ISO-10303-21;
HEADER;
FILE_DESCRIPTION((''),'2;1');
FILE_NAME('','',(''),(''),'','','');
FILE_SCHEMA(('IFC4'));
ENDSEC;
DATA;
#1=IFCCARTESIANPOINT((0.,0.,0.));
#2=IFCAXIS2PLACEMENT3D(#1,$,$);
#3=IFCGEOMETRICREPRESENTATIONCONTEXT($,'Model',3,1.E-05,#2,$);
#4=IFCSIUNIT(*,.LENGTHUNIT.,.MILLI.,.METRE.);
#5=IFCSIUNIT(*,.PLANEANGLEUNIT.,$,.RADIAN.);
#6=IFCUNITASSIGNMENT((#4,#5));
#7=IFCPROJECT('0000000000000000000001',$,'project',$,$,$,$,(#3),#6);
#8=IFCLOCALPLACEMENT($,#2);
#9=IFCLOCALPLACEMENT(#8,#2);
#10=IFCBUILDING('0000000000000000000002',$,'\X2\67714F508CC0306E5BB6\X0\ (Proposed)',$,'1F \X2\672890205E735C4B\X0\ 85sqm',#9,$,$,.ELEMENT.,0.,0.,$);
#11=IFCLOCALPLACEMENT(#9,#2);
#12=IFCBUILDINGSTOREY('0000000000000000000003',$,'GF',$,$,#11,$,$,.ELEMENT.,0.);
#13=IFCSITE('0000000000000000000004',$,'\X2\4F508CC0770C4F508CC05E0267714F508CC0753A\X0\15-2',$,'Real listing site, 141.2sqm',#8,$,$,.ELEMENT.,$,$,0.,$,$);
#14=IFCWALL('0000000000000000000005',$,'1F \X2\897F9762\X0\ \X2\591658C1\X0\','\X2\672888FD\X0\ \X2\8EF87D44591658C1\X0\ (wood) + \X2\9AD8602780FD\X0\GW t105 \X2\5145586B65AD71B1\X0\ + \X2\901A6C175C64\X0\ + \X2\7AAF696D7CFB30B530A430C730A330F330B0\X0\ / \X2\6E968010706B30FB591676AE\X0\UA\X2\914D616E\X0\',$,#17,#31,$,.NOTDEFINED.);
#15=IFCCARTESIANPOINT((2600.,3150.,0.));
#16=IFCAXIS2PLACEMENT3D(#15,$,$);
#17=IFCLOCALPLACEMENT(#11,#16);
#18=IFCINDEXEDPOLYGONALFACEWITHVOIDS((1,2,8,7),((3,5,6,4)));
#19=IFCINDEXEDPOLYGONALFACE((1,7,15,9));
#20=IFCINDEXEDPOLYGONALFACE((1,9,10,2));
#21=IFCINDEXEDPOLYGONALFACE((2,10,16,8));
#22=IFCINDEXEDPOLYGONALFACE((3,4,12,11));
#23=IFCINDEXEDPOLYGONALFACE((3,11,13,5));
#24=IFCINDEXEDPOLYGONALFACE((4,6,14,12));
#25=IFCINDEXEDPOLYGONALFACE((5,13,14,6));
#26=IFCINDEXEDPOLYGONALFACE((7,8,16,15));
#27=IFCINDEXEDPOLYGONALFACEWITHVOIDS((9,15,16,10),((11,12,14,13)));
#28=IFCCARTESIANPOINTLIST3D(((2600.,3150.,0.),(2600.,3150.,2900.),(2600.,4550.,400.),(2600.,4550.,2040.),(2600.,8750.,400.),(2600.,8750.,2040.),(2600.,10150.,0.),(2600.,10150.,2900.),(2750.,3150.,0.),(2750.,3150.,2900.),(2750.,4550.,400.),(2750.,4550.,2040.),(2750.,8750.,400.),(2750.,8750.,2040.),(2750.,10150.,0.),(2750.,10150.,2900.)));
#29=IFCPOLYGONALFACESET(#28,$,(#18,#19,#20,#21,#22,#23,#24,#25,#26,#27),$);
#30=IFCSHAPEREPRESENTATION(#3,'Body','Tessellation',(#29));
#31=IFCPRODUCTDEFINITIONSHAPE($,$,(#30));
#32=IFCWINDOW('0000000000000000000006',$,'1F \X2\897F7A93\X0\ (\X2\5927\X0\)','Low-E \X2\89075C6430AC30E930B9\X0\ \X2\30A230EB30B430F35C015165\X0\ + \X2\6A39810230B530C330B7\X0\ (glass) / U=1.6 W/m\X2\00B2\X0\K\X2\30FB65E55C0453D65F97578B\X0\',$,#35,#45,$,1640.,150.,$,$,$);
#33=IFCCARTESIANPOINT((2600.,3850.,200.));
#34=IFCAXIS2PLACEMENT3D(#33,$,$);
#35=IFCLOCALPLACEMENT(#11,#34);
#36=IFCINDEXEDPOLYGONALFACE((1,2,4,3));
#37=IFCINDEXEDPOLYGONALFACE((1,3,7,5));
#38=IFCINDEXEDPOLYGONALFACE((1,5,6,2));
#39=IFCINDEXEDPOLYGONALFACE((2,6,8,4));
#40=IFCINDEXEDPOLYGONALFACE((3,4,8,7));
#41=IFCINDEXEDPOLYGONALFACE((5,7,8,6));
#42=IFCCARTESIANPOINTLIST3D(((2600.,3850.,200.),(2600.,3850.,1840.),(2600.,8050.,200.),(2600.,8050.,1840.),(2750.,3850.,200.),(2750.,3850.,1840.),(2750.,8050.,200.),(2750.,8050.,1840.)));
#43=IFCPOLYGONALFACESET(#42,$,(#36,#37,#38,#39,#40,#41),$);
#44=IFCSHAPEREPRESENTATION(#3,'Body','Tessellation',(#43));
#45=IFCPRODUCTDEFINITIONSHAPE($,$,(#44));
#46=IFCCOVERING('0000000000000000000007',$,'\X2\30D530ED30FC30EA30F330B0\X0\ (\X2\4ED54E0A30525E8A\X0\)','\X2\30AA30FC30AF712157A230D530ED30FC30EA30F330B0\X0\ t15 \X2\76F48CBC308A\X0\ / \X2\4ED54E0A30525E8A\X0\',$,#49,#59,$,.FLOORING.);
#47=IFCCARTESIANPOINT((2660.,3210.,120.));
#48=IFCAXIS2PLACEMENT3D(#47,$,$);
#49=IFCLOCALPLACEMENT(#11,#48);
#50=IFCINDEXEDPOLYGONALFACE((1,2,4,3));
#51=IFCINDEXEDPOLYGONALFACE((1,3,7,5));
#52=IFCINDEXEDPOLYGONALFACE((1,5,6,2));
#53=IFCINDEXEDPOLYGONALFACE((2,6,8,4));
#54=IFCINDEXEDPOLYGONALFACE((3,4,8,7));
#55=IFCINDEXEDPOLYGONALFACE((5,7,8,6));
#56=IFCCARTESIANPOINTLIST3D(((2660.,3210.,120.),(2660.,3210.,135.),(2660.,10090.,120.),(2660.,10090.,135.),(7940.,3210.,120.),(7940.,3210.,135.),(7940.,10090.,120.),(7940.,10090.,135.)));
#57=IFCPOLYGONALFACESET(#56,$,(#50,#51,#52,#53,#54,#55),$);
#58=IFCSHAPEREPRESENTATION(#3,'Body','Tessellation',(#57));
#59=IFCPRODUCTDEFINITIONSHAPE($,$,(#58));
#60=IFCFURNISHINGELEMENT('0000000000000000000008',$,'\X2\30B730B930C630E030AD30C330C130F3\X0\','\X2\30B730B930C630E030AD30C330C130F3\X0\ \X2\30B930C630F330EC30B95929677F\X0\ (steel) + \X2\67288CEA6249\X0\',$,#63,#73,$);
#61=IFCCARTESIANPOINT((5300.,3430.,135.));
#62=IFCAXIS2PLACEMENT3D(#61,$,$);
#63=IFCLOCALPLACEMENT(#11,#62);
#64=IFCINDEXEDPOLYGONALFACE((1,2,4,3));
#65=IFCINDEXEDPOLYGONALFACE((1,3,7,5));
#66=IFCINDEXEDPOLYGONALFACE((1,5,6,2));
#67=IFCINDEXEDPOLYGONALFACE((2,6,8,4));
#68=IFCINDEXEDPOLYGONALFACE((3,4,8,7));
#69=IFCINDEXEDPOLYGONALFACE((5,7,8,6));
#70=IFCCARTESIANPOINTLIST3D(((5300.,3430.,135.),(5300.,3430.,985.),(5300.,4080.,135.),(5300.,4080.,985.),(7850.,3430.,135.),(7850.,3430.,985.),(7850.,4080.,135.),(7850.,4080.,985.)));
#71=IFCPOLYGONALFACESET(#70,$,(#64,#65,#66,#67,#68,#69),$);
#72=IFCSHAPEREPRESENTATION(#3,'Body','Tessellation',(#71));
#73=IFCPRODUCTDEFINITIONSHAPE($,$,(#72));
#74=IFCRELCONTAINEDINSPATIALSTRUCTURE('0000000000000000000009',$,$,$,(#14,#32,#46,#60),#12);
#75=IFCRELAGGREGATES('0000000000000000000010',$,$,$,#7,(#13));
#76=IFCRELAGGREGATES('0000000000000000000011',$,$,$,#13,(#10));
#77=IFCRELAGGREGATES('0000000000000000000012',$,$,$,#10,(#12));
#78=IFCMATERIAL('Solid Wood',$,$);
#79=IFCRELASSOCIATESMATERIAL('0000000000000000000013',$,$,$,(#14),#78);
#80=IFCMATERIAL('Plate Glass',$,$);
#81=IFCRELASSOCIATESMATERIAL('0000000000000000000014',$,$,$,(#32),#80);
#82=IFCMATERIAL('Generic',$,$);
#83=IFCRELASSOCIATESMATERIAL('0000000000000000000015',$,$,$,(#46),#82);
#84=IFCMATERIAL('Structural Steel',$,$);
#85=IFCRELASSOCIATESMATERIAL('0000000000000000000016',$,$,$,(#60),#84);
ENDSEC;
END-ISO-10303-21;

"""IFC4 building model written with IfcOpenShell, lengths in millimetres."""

from ifc_helpers import new_model, si_unit, frame, frame_2d, origin, place, context, project, spatial, rectangle, extrude, material, element, fill, save


model = new_model("IFC4")

# Units and contexts
model_context = context("Model", 3, precision=1e-05, world=origin())
ifc_project = project(units=[si_unit("LENGTHUNIT", "METRE", prefix="MILLI"), si_unit("PLANEANGLEUNIT", "RADIAN")], contexts=[model_context])

# Site, building, storey
site_placement = place(None, origin())
site = spatial("IfcSite", under=ifc_project, at=site_placement, Name="佐賀県佐賀市東佐賀町15-2", ObjectType="Real listing site, 141.2sqm", CompositionType="ELEMENT", RefElevation=0.0)
building_placement = place(site_placement, origin())
building = spatial("IfcBuilding", under=site, at=building_placement, Name="東佐賀の家 (Proposed)", ObjectType="1F 木造平屋 85sqm", CompositionType="ELEMENT", ElevationOfRefHeight=0.0, ElevationOfTerrain=0.0)
storey_placement = place(building_placement, origin())
storey = spatial("IfcBuildingStorey", under=building, at=storey_placement, Name="GF", CompositionType="ELEMENT", Elevation=0.0)

# Shared definitions
ifc_material_1 = material(Name="Solid Wood")
ifc_material_2 = material(Name="Generic")

# Shared definitions
ifc_material_3 = material(Name="Plate Glass")

# Wall, opening, window
wall_1_placement = place(storey_placement, frame((2600.0, 3150.0, 0.0)))
wall_1 = element("IfcWall", 1, at=wall_1_placement, inside=storey, material=ifc_material_1, Name="1F 西面 外壁", Description="木製 軸組外壁 (wood) + 高性能GW t105 充填断熱 + 通気層 + 窯業系サイディング / 準耐火・外皮UA配慮", PredefinedType="NOTDEFINED", context=model_context, shape_type="SweptSolid", body=[
    extrude(rectangle(XDim=150.0, YDim=7000.0, at=frame_2d((75.0, 3500.0))), frame((2600.0, 3150.0, 0.0)), (0.0, 0.0, 1.0), 2900.0),
])
opening_1_placement = place(storey_placement, frame((2600.0, 3850.0, 200.0)))
opening_1 = element("IfcOpeningElement", 2, at=opening_1_placement, cuts=wall_1, PredefinedType="NOTDEFINED", context=model_context, shape_type="SweptSolid", body=[
    extrude(rectangle(XDim=150.0, YDim=4200.0, at=frame_2d((75.0, 2100.0))), frame((2600.0, 3850.0, 200.0)), (0.0, 0.0, 1.0), 1640.0),
])
window_1_placement = place(storey_placement, frame((2600.0, 3850.0, 200.0)))
window_1 = element("IfcWindow", 3, at=window_1_placement, inside=storey, material=ifc_material_3, Name="1F 西窓 (大)", Description="Low-E 複層ガラス アルゴン封入 + 樹脂サッシ (glass) / U=1.6 W/m²K・日射取得型", OverallHeight=1640.0, OverallWidth=150.0, context=model_context, shape_type="SweptSolid", body=[
    extrude(rectangle(XDim=150.0, YDim=4200.0, at=frame_2d((75.0, 2100.0))), frame((2600.0, 3850.0, 200.0)), (0.0, 0.0, 1.0), 1640.0),
])
fill(opening_1, window_1)

# Covering
covering_placement = place(storey_placement, frame((2660.0, 3210.0, 120.0)))
element("IfcCovering", 4, at=covering_placement, inside=storey, material=ifc_material_2, Name="フローリング (仕上げ床)", Description="オーク無垢フローリング t15 直貼り / 仕上げ床", PredefinedType="FLOORING", context=model_context, shape_type="SweptSolid", body=[
    extrude(rectangle(XDim=5280.0, YDim=6880.0, at=frame_2d((2640.0, 3440.0))), frame((2660.0, 3210.0, 120.0)), (0.0, 0.0, 1.0), 15.0),
])

# Furnishing element
ifc_material_4 = material(Name="Structural Steel")
furnishing_placement = place(storey_placement, frame((5300.0, 3430.0, 135.0)))
element("IfcFurnishingElement", 5, at=furnishing_placement, inside=storey, material=ifc_material_4, Name="システムキッチン", Description="システムキッチン ステンレス天板 (steel) + 木質扉", context=model_context, shape_type="SweptSolid", body=[
    extrude(rectangle(XDim=2550.0, YDim=650.0, at=frame_2d((1275.0, 325.0))), frame((5300.0, 3430.0, 135.0)), (0.0, 0.0, 1.0), 850.0),
])

save(model, "model.ifc")
